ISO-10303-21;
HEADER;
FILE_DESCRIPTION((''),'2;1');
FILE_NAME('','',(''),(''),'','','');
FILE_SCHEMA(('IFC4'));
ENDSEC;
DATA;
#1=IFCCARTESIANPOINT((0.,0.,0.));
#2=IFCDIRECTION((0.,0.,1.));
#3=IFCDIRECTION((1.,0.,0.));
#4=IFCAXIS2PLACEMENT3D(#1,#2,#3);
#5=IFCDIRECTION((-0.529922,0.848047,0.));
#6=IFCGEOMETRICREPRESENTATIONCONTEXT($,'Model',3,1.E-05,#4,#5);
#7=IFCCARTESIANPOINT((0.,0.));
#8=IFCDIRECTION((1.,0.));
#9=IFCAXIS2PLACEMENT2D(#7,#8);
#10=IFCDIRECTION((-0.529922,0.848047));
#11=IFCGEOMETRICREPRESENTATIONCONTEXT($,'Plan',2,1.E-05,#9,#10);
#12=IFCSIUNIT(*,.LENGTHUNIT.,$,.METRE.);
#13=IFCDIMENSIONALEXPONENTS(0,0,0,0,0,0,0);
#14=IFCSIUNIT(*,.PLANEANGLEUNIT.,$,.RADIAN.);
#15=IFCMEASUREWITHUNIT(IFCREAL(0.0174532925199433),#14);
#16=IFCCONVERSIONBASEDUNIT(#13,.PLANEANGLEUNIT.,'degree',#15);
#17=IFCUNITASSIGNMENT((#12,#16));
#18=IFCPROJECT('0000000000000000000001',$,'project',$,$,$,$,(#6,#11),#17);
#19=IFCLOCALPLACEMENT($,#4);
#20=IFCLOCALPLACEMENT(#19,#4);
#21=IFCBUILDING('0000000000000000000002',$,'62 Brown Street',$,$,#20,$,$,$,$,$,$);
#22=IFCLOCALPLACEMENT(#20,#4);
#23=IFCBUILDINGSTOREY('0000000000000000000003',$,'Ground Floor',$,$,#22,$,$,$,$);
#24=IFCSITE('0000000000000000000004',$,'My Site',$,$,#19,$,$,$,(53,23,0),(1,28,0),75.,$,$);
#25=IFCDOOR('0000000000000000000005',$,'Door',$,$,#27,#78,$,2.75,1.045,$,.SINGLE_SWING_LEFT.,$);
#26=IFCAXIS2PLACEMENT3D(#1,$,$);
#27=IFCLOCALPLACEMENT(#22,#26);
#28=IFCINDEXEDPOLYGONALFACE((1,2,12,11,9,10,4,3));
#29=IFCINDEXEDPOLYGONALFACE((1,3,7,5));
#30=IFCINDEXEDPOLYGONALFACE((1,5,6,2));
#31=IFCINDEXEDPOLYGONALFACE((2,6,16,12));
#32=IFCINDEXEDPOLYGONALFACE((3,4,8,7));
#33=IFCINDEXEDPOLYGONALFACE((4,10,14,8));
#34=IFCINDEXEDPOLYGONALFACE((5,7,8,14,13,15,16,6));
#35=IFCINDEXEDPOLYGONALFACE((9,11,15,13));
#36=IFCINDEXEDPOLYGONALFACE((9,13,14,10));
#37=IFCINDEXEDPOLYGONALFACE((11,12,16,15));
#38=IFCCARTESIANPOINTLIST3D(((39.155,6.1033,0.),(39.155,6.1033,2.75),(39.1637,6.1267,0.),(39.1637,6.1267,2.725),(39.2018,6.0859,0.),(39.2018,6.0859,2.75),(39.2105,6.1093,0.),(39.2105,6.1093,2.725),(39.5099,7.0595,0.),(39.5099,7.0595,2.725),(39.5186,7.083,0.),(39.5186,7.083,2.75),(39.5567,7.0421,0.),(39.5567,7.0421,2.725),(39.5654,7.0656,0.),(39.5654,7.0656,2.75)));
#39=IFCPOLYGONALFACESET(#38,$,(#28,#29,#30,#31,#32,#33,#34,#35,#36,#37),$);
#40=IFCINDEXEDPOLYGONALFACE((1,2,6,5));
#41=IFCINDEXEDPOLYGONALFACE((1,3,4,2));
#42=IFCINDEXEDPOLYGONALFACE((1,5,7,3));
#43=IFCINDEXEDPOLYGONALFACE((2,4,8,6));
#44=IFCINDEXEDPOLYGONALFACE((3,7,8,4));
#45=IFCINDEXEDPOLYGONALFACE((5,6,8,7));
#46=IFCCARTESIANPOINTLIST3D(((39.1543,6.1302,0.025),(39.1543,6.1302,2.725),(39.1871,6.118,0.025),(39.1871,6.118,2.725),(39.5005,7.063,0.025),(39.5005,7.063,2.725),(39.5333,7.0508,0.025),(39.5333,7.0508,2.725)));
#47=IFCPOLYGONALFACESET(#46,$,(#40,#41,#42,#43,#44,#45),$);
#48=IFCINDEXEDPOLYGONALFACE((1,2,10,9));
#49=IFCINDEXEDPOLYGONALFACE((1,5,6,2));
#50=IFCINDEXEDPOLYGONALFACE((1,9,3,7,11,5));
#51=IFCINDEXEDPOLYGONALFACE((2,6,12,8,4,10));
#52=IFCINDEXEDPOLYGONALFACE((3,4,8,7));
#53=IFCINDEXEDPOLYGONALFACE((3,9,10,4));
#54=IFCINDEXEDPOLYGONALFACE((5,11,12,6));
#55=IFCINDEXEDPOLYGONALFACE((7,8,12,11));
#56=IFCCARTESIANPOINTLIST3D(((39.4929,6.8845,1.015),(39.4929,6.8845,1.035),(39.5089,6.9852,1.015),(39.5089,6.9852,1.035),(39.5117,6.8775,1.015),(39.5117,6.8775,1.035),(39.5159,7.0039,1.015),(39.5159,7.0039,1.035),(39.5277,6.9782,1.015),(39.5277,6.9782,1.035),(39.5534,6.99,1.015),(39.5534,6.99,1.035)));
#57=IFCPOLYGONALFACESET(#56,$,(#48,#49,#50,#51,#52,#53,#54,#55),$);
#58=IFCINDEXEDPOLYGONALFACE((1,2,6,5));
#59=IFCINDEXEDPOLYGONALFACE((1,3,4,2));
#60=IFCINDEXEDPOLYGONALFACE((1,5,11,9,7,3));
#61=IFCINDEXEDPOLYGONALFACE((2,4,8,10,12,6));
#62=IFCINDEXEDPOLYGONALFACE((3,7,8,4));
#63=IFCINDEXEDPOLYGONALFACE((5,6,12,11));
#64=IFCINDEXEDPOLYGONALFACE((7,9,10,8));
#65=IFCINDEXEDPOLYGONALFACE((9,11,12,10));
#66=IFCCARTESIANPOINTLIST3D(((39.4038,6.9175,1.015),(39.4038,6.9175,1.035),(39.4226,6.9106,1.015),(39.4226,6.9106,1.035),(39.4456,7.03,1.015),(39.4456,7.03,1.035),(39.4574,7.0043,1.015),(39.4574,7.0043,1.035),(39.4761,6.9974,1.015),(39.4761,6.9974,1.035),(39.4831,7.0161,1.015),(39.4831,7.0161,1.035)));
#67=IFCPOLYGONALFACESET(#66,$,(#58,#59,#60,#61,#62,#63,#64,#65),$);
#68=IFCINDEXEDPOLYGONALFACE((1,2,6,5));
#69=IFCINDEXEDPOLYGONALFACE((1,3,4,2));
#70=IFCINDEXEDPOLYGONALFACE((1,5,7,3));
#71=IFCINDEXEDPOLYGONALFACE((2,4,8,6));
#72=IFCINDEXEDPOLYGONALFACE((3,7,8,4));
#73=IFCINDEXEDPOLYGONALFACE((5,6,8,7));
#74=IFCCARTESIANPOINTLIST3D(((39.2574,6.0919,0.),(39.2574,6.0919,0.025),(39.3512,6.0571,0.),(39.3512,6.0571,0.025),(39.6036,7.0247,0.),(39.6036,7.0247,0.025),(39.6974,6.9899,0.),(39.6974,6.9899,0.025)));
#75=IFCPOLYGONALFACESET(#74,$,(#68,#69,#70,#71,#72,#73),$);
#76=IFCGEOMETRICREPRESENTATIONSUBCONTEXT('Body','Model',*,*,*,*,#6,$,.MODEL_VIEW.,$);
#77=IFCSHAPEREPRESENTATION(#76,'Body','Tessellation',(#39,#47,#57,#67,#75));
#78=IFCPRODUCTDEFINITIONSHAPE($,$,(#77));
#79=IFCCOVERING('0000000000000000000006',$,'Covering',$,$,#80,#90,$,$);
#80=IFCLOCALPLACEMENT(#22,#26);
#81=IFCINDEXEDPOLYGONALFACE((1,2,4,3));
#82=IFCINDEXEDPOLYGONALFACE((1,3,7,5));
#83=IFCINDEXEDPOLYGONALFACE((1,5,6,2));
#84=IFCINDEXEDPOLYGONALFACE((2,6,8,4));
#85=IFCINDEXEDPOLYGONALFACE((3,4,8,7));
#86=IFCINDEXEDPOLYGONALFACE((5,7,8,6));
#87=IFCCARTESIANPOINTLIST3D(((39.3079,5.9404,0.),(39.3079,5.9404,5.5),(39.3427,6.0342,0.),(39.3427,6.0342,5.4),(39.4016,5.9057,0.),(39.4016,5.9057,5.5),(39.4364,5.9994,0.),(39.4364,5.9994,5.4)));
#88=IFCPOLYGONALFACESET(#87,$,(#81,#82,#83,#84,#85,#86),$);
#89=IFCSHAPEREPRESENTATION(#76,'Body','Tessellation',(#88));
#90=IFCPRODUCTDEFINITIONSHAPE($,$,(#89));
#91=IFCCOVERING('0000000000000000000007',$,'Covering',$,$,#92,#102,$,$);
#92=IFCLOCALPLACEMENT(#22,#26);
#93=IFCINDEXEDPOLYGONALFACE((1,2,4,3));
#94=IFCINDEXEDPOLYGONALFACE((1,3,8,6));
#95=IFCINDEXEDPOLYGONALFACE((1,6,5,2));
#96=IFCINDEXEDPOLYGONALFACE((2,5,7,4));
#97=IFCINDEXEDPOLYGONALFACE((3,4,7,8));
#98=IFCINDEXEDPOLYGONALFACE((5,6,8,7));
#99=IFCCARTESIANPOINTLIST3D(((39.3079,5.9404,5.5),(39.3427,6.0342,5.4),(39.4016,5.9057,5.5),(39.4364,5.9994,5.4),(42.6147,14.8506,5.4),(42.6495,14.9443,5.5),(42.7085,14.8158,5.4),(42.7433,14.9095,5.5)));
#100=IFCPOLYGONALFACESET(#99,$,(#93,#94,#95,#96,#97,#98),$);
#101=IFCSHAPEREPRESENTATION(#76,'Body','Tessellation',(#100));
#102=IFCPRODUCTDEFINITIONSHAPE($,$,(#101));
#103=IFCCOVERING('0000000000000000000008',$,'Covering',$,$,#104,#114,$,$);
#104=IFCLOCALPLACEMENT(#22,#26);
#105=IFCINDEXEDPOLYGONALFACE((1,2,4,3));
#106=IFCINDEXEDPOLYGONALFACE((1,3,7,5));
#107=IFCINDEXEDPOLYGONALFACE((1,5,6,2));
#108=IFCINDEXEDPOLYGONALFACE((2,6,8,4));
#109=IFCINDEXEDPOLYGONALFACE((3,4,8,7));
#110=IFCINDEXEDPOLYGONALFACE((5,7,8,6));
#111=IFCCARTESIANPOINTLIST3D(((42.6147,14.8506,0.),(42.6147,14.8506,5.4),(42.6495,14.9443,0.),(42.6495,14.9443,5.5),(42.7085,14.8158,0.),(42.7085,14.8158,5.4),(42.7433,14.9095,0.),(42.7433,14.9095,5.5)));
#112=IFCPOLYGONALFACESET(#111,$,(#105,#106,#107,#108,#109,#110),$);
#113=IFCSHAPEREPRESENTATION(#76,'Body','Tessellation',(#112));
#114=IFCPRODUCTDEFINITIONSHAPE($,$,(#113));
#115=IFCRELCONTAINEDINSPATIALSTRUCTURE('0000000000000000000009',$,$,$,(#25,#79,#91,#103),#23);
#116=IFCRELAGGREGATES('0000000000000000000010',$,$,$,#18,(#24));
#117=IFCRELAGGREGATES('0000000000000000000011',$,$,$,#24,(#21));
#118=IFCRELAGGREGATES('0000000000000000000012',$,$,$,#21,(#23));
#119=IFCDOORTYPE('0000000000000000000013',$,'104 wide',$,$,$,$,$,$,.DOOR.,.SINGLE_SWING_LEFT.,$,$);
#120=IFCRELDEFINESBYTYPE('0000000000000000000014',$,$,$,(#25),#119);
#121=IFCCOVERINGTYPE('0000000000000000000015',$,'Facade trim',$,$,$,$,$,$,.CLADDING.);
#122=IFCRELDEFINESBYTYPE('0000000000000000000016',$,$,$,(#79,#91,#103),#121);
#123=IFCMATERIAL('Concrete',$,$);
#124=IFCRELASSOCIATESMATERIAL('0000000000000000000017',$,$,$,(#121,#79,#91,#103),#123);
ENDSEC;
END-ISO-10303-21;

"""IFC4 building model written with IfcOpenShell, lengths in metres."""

from ifc_helpers import new_model, entity, si_unit, converted_unit, direction, frame, origin_with_axes, origin_2d_with_axis, place, context, subcontext, project, spatial, line, indexed_curve, rectangle, outline, extrude, clip, halfspace, shape, source, transform, mapped, material, material_profile, profile_set, profile_usage, type_object, type_shapes, element, save


model = new_model("IFC4")

# Units and contexts
model_context = context("Model", 3, precision=1e-05, world=origin_with_axes(), true_north=direction((-0.529922, 0.848047, 0.0)))
plan_context = context("Plan", 2, precision=1e-05, world=origin_2d_with_axis(), true_north=direction((-0.529922, 0.848047)))
body_context_1 = subcontext(model_context, "Body", "Model", "MODEL_VIEW")
body_context_2 = subcontext(plan_context, "Body", "Plan", "PLAN_VIEW")
ifc_project = project(units=[si_unit("LENGTHUNIT", "METRE"), converted_unit("PLANEANGLEUNIT", "degree", entity("IfcReal", 0.0174532925199433), si_unit("PLANEANGLEUNIT", "RADIAN"), dimensions=[0, 0, 0, 0, 0, 0, 0])], contexts=[model_context, plan_context])

# Site, building, storey
site_placement = place(None, origin_with_axes())
site = spatial("IfcSite", under=ifc_project, at=site_placement, Name="My Site", RefLatitude=(53, 23, 0), RefLongitude=(1, 28, 0), RefElevation=75.0)
building_placement = place(site_placement, origin_with_axes())
building = spatial("IfcBuilding", under=site, at=building_placement, Name="62 Brown Street")
storey_placement = place(building_placement, origin_with_axes())
storey = spatial("IfcBuildingStorey", under=building, at=storey_placement, Name="Ground Floor")

# Shared definitions
ifc_material_1 = material(Name="Concrete")

# Shared definitions
placement_1 = place(storey_placement, frame((39.024, 5.1755, 0.0), z_axis=(0.0, 0.0, 1.0), x_axis=(0.347944, 0.937515, 0.0)))

# Door
door_type_1 = type_object("IfcDoorType", Name="104 wide", OperationType="SINGLE_SWING_LEFT", PredefinedType="DOOR")
shared_shape_1 = source(origin_with_axes(), body_context_1, "Body", "SweptSolid", [
    extrude(outline(indexed_curve([(0.0, 0.0), (0.0, 2.75), (1.045, 2.75), (1.045, 0.0), (1.02, 0.0), (1.02, 2.725), (0.025, 2.725), (0.025, 0.0)], segments=[line(1, 2, 3, 4, 5, 6, 7, 8, 1)])), frame((0.0, 0.15, 0.0), z_axis=(0.0, -1.0, 0.0), x_axis=(1.0, 0.0, 0.0)), (0.0, 0.0, -1.0), 0.05),
    extrude(outline(indexed_curve([(0.0, 0.0), (0.995, 0.0), (0.995, 0.035), (0.0, 0.035)], segments=[line(1, 2, 3, 4, 1)])), frame((0.025, 0.175, 0.025), z_axis=(0.0, 0.0, 1.0), x_axis=(1.0, 0.0, 0.0)), (0.0, 0.0, 1.0), 2.7),
    extrude(outline(indexed_curve([(0.0, 0.0), (0.0, -0.04), (-0.12, -0.04), (-0.12, -0.02), (-0.02, -0.02), (-0.02, 0.0)], segments=[line(1, 2, 3, 4, 5, 6, 1)])), frame((0.97, 0.175, 1.015), z_axis=(0.0, 0.0, 1.0), x_axis=(1.0, 0.0, 0.0)), (0.0, 0.0, 1.0), 0.02),
    extrude(outline(indexed_curve([(0.0, 0.0), (0.0, 0.04), (-0.12, 0.04), (-0.12, 0.02), (-0.02, 0.02), (-0.02, 0.0)], segments=[line(1, 2, 3, 4, 5, 6, 1)])), frame((0.97, 0.21, 1.015), z_axis=(0.0, 0.0, 1.0), x_axis=(1.0, 0.0, 0.0)), (0.0, 0.0, 1.0), 0.02),
    extrude(outline(indexed_curve([(0.0, 0.0), (0.995, 0.0), (0.995, 0.1), (0.0, 0.1)], segments=[line(1, 2, 3, 4, 1)])), frame((0.025, 0.0, 0.0), z_axis=(0.0, 0.0, 1.0), x_axis=(1.0, 0.0, 0.0)), (0.0, 0.0, 1.0), 0.025),
])
shared_shape_2 = source(origin_with_axes(), body_context_2, "Body", "Curve2D", [
    entity("IfcIndexedPolyCurve", entity("IfcCartesianPointList2D", [[0.0, 0.15], [0.025, 0.15], [0.025, 0.2], [0.0, 0.2]]), [entity("IfcLineIndex", [1, 2, 3, 4, 1])]),
    entity("IfcIndexedPolyCurve", entity("IfcCartesianPointList2D", [[1.045, 0.15], [1.02, 0.15], [1.02, 0.2], [1.045, 0.2]]), [entity("IfcLineIndex", [1, 2, 3, 4, 1])]),
    entity("IfcTrimmedCurve", entity("IfcEllipse", entity("IfcAxis2Placement2D", entity("IfcCartesianPoint", [0.06, 0.2]), entity("IfcDirection", [1.0, 0.0])), 0.96, 0.995), [entity("IfcCartesianPoint", [1.02, 0.2])], [entity("IfcCartesianPoint", [0.06, 1.195])], True, "CARTESIAN"),
    entity("IfcIndexedPolyCurve", entity("IfcCartesianPointList2D", [[0.025, 0.2], [0.06, 0.2], [0.06, 1.195], [0.025, 1.195]]), [entity("IfcLineIndex", [1, 2, 3, 4, 1])]),
])
type_shapes(door_type_1, [shared_shape_1, shared_shape_2])
placement_2 = place(placement_1, frame((0.9154, 0.0, 0.0), z_axis=(0.0, 0.0, 1.0), x_axis=(1.0, 0.0, 0.0)))
door_1_placement = place(placement_2, frame((0.0, 0.0, 0.0), z_axis=(0.0, 0.0, 1.0), x_axis=(1.0, 0.0, 0.0)))
element("IfcDoor", 1, at=door_1_placement, inside=storey, type_object=door_type_1, Name="Door", OperationType="SINGLE_SWING_LEFT", OverallHeight=2.75, OverallWidth=1.045, shapes=[
    shape(body_context_1, "Body", "MappedRepresentation", [mapped(shared_shape_1, transform((0.0, 0.0, 0.0), x_axis=(1.0, 0.0, 0.0), y_axis=(0.0, 1.0, 0.0), z_axis=(0.0, 0.0, 1.0), scale=1.0))]),
    shape(body_context_2, "Body", "MappedRepresentation", [mapped(shared_shape_2, transform((0.0, 0.0, 0.0), x_axis=(1.0, 0.0, 0.0), y_axis=(0.0, 1.0, 0.0), z_axis=(0.0, 0.0, 1.0), scale=1.0))]),
])

# Coverings
ifc_material_profile = material_profile(ifc_material_1, rectangle(XDim=0.1, YDim=0.1))
ifc_profile_set = profile_set([ifc_material_profile], Name="cowl")
ifc_profile_usage_1 = profile_usage(ifc_profile_set, cardinal=5)
covering_type = type_object("IfcCoveringType", Name="Facade trim", PredefinedType="CLADDING", material=ifc_profile_set)
covering_1_placement = place(storey_placement, frame((39.3721, 5.9699, 0.0), z_axis=(0.0, 0.0, 1.0), x_axis=(0.347944, 0.937515, 0.0)))
element("IfcCovering", 2, at=covering_1_placement, inside=storey, type_object=covering_type, material=ifc_profile_usage_1, Name="Covering", context=body_context_1, shape_type="Clipping", body=[
    clip(extrude(rectangle(XDim=0.1, YDim=0.1), origin_with_axes(), (0.0, 0.0, 1.0), 5.5), halfspace(frame((-0.05, 34.8348, 5.5), z_axis=(0.707098, 0.0, 0.707116), x_axis=(0.707116, 0.0, -0.707098)), False)),
])
ifc_profile_usage_2 = profile_usage(ifc_profile_set, cardinal=5)
covering_2_placement = place(storey_placement, frame((39.3547, 5.923, 5.45), z_axis=(0.347944, 0.937515, 0.0), x_axis=(0.0, 0.0, -1.0)))
element("IfcCovering", 3, at=covering_2_placement, inside=storey, type_object=covering_type, material=ifc_profile_usage_2, Name="Covering", context=body_context_1, shape_type="Clipping", body=[
    clip(clip(extrude(rectangle(XDim=0.1, YDim=0.1), origin_with_axes(), (0.0, 0.0, 1.0), 9.604), halfspace(frame((-0.05, 34.8348, 9.604), z_axis=(0.707114, 0.0, 0.7071), x_axis=(0.7071, -0.000003, -0.707113)), False)), halfspace(frame((-0.05, 34.8348, 0.0), z_axis=(0.707116, 0.0, -0.707098), x_axis=(0.707098, 0.0, 0.707116)), False)),
])
ifc_profile_usage_3 = profile_usage(ifc_profile_set, cardinal=5)
covering_3_placement = place(storey_placement, frame((42.679, 14.8801, 5.5), z_axis=(0.0, 0.0, -1.0), x_axis=(-0.347944, -0.937515, 0.0)))
element("IfcCovering", 4, at=covering_3_placement, inside=storey, type_object=covering_type, material=ifc_profile_usage_3, Name="Covering", context=body_context_1, shape_type="Clipping", body=[
    clip(extrude(rectangle(XDim=0.1, YDim=0.1), origin_with_axes(), (0.0, 0.0, 1.0), 5.5), halfspace(frame((-0.05, 34.8348, 0.0), z_axis=(0.7071, 0.0, -0.707113), x_axis=(0.707113, -0.000003, 0.7071)), False)),
])

save(model, "model.ifc")
